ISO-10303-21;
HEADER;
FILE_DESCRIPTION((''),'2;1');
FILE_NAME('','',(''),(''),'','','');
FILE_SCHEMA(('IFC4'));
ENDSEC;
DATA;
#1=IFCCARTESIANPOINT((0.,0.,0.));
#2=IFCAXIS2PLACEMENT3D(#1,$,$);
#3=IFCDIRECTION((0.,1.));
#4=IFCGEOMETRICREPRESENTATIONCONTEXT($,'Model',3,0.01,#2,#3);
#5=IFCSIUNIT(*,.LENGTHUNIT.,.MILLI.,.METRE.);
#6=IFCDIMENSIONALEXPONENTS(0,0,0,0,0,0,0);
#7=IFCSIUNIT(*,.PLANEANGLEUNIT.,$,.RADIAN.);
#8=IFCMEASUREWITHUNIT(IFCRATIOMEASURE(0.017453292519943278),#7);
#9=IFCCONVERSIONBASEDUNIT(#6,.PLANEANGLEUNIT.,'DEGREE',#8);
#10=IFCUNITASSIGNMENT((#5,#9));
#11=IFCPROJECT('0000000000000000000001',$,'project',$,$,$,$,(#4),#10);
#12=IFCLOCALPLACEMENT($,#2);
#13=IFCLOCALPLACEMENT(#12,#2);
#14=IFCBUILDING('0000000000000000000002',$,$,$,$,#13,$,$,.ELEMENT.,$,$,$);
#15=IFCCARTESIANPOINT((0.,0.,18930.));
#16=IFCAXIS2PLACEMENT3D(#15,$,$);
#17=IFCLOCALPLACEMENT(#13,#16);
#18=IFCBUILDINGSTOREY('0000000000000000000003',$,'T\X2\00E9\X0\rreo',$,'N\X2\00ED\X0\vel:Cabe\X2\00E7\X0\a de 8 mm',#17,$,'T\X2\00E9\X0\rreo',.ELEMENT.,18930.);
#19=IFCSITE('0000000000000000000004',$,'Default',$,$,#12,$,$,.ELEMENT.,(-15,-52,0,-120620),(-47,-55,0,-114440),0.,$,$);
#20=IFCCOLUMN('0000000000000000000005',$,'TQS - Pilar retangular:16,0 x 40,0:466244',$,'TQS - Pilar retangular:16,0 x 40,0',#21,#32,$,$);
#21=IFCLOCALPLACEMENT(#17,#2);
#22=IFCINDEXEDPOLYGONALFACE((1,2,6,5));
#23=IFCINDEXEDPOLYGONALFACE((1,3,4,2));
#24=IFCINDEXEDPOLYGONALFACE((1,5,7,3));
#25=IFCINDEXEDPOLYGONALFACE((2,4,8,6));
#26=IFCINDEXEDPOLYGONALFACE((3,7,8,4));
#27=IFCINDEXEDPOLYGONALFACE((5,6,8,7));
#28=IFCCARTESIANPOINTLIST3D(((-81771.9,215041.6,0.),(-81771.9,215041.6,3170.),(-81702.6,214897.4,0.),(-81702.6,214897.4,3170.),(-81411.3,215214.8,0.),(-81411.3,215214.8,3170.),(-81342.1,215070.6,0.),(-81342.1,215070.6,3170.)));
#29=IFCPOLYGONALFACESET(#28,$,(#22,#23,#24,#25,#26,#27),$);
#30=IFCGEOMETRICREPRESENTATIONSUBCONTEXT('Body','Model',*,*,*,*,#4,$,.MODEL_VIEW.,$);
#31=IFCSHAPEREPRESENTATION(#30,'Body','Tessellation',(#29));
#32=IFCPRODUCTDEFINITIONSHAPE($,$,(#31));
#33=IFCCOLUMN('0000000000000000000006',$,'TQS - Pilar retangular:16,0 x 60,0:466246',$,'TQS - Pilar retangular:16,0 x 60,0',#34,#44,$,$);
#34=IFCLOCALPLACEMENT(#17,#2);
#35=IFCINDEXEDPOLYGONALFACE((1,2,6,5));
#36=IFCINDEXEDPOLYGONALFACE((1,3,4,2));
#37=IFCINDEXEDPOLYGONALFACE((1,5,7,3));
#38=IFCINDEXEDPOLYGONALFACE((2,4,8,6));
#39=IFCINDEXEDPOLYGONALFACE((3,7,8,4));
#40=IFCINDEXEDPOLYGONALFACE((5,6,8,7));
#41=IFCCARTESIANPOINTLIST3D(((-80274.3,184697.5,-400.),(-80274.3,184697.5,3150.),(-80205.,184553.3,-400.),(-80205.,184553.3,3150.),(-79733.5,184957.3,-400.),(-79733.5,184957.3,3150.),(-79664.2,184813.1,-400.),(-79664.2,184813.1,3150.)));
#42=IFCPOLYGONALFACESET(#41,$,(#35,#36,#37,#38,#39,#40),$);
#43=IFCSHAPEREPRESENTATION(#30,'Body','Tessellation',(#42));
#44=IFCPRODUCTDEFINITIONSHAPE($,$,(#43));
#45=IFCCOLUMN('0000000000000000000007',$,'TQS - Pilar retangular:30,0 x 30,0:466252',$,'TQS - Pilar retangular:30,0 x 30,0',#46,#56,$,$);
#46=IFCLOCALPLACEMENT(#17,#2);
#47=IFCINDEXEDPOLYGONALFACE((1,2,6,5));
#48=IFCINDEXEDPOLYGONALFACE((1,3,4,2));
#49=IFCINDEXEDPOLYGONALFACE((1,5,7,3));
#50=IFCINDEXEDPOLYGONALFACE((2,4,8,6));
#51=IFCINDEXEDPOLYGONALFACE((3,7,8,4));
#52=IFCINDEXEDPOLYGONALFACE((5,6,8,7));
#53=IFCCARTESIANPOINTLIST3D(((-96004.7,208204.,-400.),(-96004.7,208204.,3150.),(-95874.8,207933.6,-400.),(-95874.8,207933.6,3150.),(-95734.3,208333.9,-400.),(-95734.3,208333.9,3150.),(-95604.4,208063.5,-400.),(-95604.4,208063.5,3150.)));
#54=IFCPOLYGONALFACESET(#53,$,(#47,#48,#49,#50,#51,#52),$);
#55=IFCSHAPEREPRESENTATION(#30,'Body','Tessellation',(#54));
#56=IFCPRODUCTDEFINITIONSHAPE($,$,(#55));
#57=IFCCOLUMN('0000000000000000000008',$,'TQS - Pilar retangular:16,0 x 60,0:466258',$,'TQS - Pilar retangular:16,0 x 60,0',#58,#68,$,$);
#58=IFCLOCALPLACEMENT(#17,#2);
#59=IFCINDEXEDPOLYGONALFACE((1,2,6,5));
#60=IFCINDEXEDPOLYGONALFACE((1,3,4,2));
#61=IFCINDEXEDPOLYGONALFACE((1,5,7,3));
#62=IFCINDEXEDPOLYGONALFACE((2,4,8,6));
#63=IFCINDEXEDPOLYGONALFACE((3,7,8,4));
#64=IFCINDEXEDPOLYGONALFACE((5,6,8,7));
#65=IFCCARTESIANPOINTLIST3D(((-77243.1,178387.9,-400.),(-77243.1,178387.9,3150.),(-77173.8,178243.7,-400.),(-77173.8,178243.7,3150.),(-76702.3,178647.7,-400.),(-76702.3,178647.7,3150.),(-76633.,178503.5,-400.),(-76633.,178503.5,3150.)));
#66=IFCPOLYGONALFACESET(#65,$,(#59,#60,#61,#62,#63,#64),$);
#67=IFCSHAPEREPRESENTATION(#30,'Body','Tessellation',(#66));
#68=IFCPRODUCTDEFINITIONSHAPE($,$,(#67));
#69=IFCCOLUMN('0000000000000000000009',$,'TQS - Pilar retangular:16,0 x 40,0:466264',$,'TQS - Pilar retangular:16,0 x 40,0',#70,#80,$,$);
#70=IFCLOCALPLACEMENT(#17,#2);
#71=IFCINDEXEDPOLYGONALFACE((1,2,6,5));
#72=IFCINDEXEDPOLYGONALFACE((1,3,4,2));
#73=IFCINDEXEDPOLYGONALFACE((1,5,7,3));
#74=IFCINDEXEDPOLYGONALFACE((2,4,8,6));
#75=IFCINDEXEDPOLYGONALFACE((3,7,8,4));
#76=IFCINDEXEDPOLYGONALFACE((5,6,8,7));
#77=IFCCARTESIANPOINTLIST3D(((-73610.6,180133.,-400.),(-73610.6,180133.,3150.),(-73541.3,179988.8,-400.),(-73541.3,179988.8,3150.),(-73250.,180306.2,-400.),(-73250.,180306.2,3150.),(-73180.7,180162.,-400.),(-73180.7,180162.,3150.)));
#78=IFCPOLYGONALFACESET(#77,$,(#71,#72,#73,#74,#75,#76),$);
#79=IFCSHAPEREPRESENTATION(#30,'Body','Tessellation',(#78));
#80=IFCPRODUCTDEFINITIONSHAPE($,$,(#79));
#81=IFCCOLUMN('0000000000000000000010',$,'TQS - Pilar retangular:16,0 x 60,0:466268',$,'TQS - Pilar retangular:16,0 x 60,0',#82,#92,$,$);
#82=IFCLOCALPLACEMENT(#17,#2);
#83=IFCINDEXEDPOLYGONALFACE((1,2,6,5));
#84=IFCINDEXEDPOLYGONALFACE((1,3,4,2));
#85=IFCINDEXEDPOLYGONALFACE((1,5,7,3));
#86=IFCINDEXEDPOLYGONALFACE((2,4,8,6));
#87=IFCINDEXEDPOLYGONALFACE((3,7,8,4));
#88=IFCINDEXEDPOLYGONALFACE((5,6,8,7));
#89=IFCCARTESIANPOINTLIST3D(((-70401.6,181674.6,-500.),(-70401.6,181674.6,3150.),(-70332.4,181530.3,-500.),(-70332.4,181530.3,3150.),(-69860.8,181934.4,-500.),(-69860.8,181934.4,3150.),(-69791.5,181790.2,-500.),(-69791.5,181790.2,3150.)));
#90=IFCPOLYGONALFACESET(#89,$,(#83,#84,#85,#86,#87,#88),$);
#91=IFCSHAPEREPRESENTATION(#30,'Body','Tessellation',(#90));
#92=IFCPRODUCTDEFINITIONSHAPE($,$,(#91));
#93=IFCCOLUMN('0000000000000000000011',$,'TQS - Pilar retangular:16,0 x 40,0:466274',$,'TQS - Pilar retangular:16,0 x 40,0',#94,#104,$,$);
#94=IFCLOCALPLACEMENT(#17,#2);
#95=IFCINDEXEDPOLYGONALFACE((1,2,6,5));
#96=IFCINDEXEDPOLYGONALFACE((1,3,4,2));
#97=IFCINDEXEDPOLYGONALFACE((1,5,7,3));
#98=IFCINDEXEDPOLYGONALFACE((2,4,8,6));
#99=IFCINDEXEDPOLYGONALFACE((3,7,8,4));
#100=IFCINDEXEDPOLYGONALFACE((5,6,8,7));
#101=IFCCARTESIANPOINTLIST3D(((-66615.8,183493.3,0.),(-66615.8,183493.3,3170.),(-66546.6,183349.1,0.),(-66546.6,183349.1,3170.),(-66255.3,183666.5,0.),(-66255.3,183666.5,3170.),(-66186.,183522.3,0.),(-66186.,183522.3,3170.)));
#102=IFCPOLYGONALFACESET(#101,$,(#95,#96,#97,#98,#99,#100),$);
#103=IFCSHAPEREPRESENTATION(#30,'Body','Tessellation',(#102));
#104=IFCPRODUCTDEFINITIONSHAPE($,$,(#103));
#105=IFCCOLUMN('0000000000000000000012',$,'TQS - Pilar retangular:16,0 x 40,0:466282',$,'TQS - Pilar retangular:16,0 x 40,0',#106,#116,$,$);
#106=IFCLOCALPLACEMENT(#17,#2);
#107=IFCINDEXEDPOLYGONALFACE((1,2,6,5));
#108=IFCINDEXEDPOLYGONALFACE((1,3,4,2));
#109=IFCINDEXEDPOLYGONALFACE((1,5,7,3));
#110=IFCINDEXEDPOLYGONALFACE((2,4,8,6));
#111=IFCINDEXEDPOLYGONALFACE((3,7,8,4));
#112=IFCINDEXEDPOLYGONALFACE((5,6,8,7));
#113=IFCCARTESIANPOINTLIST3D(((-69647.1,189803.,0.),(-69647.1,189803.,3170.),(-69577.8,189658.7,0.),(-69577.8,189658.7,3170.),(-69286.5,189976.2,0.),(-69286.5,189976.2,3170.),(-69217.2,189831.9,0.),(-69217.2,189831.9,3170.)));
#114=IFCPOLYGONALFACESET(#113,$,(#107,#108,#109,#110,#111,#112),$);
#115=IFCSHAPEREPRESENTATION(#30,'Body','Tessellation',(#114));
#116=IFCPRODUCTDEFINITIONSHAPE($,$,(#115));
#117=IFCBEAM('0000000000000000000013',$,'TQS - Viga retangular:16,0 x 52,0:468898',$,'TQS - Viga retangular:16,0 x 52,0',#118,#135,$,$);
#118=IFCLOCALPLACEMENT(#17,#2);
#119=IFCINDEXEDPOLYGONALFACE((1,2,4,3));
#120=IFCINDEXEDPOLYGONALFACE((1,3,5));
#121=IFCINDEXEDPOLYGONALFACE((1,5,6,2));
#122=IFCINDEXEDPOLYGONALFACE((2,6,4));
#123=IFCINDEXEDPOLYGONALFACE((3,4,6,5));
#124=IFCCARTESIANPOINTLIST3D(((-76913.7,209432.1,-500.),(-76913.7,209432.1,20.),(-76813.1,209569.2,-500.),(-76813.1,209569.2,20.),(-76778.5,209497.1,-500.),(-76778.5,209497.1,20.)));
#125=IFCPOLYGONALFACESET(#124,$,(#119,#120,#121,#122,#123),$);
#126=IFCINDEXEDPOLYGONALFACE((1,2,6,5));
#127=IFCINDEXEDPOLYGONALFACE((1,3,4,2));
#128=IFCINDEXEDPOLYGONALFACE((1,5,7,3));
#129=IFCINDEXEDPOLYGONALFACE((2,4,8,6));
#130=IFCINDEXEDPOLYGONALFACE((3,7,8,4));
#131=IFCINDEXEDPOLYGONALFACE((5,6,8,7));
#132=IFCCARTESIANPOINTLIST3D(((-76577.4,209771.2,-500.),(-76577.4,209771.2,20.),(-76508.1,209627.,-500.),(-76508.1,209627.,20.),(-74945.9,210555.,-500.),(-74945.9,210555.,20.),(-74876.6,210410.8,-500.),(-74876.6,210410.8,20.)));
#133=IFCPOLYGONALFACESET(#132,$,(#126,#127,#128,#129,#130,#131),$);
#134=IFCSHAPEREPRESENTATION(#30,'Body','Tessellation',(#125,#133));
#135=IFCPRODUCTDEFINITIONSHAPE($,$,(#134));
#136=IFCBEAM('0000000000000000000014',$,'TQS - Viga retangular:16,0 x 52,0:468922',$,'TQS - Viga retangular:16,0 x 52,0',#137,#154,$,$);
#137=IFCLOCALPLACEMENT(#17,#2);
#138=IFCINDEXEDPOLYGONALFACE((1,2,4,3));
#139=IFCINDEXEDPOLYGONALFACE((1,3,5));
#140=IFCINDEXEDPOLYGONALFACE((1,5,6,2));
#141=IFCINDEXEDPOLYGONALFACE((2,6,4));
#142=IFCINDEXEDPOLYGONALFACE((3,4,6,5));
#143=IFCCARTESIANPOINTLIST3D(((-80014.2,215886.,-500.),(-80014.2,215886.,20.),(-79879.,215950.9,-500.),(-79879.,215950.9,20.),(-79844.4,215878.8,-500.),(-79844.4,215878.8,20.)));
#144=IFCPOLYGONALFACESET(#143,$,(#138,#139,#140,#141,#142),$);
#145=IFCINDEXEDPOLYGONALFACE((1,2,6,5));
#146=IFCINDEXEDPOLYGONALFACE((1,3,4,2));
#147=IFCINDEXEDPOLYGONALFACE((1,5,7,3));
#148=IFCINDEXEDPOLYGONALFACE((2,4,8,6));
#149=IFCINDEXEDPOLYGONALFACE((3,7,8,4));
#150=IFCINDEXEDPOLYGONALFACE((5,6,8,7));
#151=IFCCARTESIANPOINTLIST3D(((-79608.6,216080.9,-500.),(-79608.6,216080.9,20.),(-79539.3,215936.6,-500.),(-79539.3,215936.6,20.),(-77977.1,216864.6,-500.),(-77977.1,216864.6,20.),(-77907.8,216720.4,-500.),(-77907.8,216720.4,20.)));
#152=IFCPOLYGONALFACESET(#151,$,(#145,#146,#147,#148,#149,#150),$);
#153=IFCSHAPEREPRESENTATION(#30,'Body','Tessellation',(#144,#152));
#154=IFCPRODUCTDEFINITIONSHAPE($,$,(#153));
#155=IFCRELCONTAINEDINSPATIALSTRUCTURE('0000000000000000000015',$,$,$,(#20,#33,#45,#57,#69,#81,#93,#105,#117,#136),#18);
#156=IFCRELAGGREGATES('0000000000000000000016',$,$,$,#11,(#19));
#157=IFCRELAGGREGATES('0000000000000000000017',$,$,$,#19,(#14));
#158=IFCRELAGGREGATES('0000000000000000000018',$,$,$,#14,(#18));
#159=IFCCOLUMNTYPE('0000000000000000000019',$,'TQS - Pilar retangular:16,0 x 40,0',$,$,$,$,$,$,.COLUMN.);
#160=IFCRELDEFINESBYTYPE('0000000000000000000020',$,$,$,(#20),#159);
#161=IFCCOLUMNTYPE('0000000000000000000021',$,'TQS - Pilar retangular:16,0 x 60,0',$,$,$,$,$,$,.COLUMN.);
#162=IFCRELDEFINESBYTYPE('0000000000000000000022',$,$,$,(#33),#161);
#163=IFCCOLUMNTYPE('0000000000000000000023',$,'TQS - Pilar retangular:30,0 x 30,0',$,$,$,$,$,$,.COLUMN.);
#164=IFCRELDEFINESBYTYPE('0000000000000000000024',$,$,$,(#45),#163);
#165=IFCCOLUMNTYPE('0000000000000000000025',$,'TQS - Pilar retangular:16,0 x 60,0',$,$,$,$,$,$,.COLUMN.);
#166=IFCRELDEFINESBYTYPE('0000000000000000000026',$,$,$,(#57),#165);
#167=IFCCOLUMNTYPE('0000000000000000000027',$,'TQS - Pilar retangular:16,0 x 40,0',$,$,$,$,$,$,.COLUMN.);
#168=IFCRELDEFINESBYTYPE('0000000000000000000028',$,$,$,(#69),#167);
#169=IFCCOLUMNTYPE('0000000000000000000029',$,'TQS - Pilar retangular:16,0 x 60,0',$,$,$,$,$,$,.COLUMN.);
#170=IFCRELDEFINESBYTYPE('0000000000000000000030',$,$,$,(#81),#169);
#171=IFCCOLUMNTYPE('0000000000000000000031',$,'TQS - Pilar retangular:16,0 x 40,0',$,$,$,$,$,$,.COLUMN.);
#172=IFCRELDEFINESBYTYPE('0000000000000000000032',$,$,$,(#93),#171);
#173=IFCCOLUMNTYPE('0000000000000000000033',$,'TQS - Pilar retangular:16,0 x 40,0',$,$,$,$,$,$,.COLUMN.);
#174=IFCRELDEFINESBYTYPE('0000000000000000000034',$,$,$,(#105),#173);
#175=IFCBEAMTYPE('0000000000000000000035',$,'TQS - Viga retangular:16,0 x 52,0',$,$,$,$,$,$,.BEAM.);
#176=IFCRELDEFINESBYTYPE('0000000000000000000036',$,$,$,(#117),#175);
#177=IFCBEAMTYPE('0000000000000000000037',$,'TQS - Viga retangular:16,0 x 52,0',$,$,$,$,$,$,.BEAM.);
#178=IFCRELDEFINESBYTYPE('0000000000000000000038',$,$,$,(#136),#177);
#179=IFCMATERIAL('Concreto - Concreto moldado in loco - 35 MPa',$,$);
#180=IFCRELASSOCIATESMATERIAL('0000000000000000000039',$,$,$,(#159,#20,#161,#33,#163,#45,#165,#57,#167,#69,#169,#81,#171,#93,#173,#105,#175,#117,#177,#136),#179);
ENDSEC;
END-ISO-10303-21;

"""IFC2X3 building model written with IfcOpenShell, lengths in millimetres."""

from ifc_helpers import new_model, entity, si_unit, converted_unit, direction, frame, frame_2d, origin, origin_2d_with_axis, place, context, subcontext, project, spatial, rectangle, extrude, clip, halfspace, source, transform, mapped, material, type_object, type_shapes, element, save


model = new_model("IFC2X3")

# Units and contexts
model_context = context("Model", 3, precision=0.01, world=origin(), true_north=direction((0.0, 1.0)))
body_context = subcontext(model_context, "Body", "Model", "MODEL_VIEW")
ifc_project = project(units=[si_unit("LENGTHUNIT", "METRE", prefix="MILLI"), converted_unit("PLANEANGLEUNIT", "DEGREE", entity("IfcRatioMeasure", 0.017453292519943278), si_unit("PLANEANGLEUNIT", "RADIAN"), dimensions=[0, 0, 0, 0, 0, 0, 0])], contexts=[model_context])

# Site, building, storey
site_placement = place(None, origin())
site = spatial("IfcSite", under=ifc_project, at=site_placement, Name="Default", CompositionType="ELEMENT", RefLatitude=(-15, -52, 0, -120620), RefLongitude=(-47, -55, 0, -114440), RefElevation=0.0)
building_placement = place(site_placement, origin())
building = spatial("IfcBuilding", under=site, at=building_placement, CompositionType="ELEMENT")
storey_placement = place(building_placement, frame((0.0, 0.0, 18930.0)))
storey = spatial("IfcBuildingStorey", under=building, at=storey_placement, Name="Térreo", ObjectType="Nível:Cabeça de 8 mm", LongName="Térreo", CompositionType="ELEMENT", Elevation=18930.0)

# Columns
ifc_material = material(Name="Concreto - Concreto moldado in loco - 35 MPa")
column_type_1 = type_object("IfcColumnType", Name="TQS - Pilar retangular:16,0 x 40,0", PredefinedType="COLUMN", material=ifc_material)
shared_shape_1 = source(origin(), body_context, "Body", "SweptSolid", [
    extrude(rectangle(XDim=400.0, YDim=160.0, at=origin_2d_with_axis()), frame((-81557.0, 215056.1, 18930.0), z_axis=(0.0, 0.0, 1.0), x_axis=(-0.90138, -0.43303, 0.0)), (0.0, 0.0, 1.0), 3170.0),
])
type_shapes(column_type_1, [shared_shape_1])
column_1_placement = place(storey_placement, frame((0.0, 0.0, -18930.0)))
element("IfcColumn", 1, at=column_1_placement, inside=storey, type_object=column_type_1, material=ifc_material, Name="TQS - Pilar retangular:16,0 x 40,0:466244", ObjectType="TQS - Pilar retangular:16,0 x 40,0", context=body_context, shape_type="MappedRepresentation", body=[
    mapped(shared_shape_1, transform((0.0, 0.0, 0.0), scale=1.0)),
])
column_type_2 = type_object("IfcColumnType", Name="TQS - Pilar retangular:16,0 x 60,0", PredefinedType="COLUMN", material=ifc_material)
shared_shape_2 = source(origin(), body_context, "Body", "SweptSolid", [
    extrude(rectangle(XDim=600.0, YDim=160.0, at=origin_2d_with_axis()), frame((-79969.3, 184755.3, 18530.0), z_axis=(0.0, 0.0, 1.0), x_axis=(-0.90138, -0.43303, 0.0)), (0.0, 0.0, 1.0), 3550.0),
])
type_shapes(column_type_2, [shared_shape_2])
column_2_placement = place(storey_placement, frame((0.0, 0.0, -18930.0)))
element("IfcColumn", 2, at=column_2_placement, inside=storey, type_object=column_type_2, material=ifc_material, Name="TQS - Pilar retangular:16,0 x 60,0:466246", ObjectType="TQS - Pilar retangular:16,0 x 60,0", context=body_context, shape_type="MappedRepresentation", body=[
    mapped(shared_shape_2, transform((0.0, 0.0, 0.0), scale=1.0)),
])
column_type_3 = type_object("IfcColumnType", Name="TQS - Pilar retangular:30,0 x 30,0", PredefinedType="COLUMN", material=ifc_material)
shared_shape_3 = source(origin(), body_context, "Body", "SweptSolid", [
    extrude(rectangle(XDim=300.0, YDim=300.0, at=origin_2d_with_axis()), frame((-95804.5, 208133.8, 18530.0), z_axis=(0.0, 0.0, 1.0), x_axis=(-0.90138, -0.43303, 0.0)), (0.0, 0.0, 1.0), 3550.0),
])
type_shapes(column_type_3, [shared_shape_3])
column_3_placement = place(storey_placement, frame((0.0, 0.0, -18930.0)))
element("IfcColumn", 3, at=column_3_placement, inside=storey, type_object=column_type_3, material=ifc_material, Name="TQS - Pilar retangular:30,0 x 30,0:466252", ObjectType="TQS - Pilar retangular:30,0 x 30,0", context=body_context, shape_type="MappedRepresentation", body=[
    mapped(shared_shape_3, transform((0.0, 0.0, 0.0), scale=1.0)),
])
column_type_4 = type_object("IfcColumnType", Name="TQS - Pilar retangular:16,0 x 60,0", PredefinedType="COLUMN", material=ifc_material)
shared_shape_4 = source(origin(), body_context, "Body", "SweptSolid", [
    extrude(rectangle(XDim=600.0, YDim=160.0, at=origin_2d_with_axis()), frame((-76938.1, 178445.7, 18530.0), z_axis=(0.0, 0.0, 1.0), x_axis=(-0.90138, -0.43303, 0.0)), (0.0, 0.0, 1.0), 3550.0),
])
type_shapes(column_type_4, [shared_shape_4])
column_4_placement = place(storey_placement, frame((0.0, 0.0, -18930.0)))
element("IfcColumn", 4, at=column_4_placement, inside=storey, type_object=column_type_4, material=ifc_material, Name="TQS - Pilar retangular:16,0 x 60,0:466258", ObjectType="TQS - Pilar retangular:16,0 x 60,0", context=body_context, shape_type="MappedRepresentation", body=[
    mapped(shared_shape_4, transform((0.0, 0.0, 0.0), scale=1.0)),
])
column_type_5 = type_object("IfcColumnType", Name="TQS - Pilar retangular:16,0 x 40,0", PredefinedType="COLUMN", material=ifc_material)
shared_shape_5 = source(origin(), body_context, "Body", "SweptSolid", [
    extrude(rectangle(XDim=400.0, YDim=160.0, at=origin_2d_with_axis()), frame((-73395.6, 180147.5, 18530.0), z_axis=(0.0, 0.0, 1.0), x_axis=(-0.90138, -0.43303, 0.0)), (0.0, 0.0, 1.0), 3550.0),
])
type_shapes(column_type_5, [shared_shape_5])
column_5_placement = place(storey_placement, frame((0.0, 0.0, -18930.0)))
element("IfcColumn", 5, at=column_5_placement, inside=storey, type_object=column_type_5, material=ifc_material, Name="TQS - Pilar retangular:16,0 x 40,0:466264", ObjectType="TQS - Pilar retangular:16,0 x 40,0", context=body_context, shape_type="MappedRepresentation", body=[
    mapped(shared_shape_5, transform((0.0, 0.0, 0.0), scale=1.0)),
])
column_type_6 = type_object("IfcColumnType", Name="TQS - Pilar retangular:16,0 x 60,0", PredefinedType="COLUMN", material=ifc_material)
shared_shape_6 = source(origin(), body_context, "Body", "SweptSolid", [
    extrude(rectangle(XDim=600.0, YDim=160.0, at=origin_2d_with_axis()), frame((-70096.6, 181732.4, 18430.0), z_axis=(0.0, 0.0, 1.0), x_axis=(-0.90138, -0.43303, 0.0)), (0.0, 0.0, 1.0), 3650.0),
])
type_shapes(column_type_6, [shared_shape_6])
column_6_placement = place(storey_placement, frame((0.0, 0.0, -18930.0)))
element("IfcColumn", 6, at=column_6_placement, inside=storey, type_object=column_type_6, material=ifc_material, Name="TQS - Pilar retangular:16,0 x 60,0:466268", ObjectType="TQS - Pilar retangular:16,0 x 60,0", context=body_context, shape_type="MappedRepresentation", body=[
    mapped(shared_shape_6, transform((0.0, 0.0, 0.0), scale=1.0)),
])
column_type_7 = type_object("IfcColumnType", Name="TQS - Pilar retangular:16,0 x 40,0", PredefinedType="COLUMN", material=ifc_material)
shared_shape_7 = source(origin(), body_context, "Body", "SweptSolid", [
    extrude(rectangle(XDim=400.0, YDim=160.0, at=origin_2d_with_axis()), frame((-66400.9, 183507.8, 18930.0), z_axis=(0.0, 0.0, 1.0), x_axis=(-0.90138, -0.43303, 0.0)), (0.0, 0.0, 1.0), 3170.0),
])
type_shapes(column_type_7, [shared_shape_7])
column_7_placement = place(storey_placement, frame((0.0, 0.0, -18930.0)))
element("IfcColumn", 7, at=column_7_placement, inside=storey, type_object=column_type_7, material=ifc_material, Name="TQS - Pilar retangular:16,0 x 40,0:466274", ObjectType="TQS - Pilar retangular:16,0 x 40,0", context=body_context, shape_type="MappedRepresentation", body=[
    mapped(shared_shape_7, transform((0.0, 0.0, 0.0), scale=1.0)),
])
column_type_8 = type_object("IfcColumnType", Name="TQS - Pilar retangular:16,0 x 40,0", PredefinedType="COLUMN", material=ifc_material)
shared_shape_8 = source(origin(), body_context, "Body", "SweptSolid", [
    extrude(rectangle(XDim=400.0, YDim=160.0, at=origin_2d_with_axis()), frame((-69432.1, 189817.4, 18930.0), z_axis=(0.0, 0.0, 1.0), x_axis=(-0.90138, -0.43303, 0.0)), (0.0, 0.0, 1.0), 3170.0),
])
type_shapes(column_type_8, [shared_shape_8])
column_8_placement = place(storey_placement, frame((0.0, 0.0, -18930.0)))
element("IfcColumn", 8, at=column_8_placement, inside=storey, type_object=column_type_8, material=ifc_material, Name="TQS - Pilar retangular:16,0 x 40,0:466282", ObjectType="TQS - Pilar retangular:16,0 x 40,0", context=body_context, shape_type="MappedRepresentation", body=[
    mapped(shared_shape_8, transform((0.0, 0.0, 0.0), scale=1.0)),
])

# Beams
beam_type_1 = type_object("IfcBeamType", Name="TQS - Viga retangular:16,0 x 52,0", PredefinedType="BEAM", material=ifc_material)
shared_shape_9 = source(origin(), body_context, "Body", "SweptSolid", [
    clip(extrude(rectangle(XDim=520.0, YDim=80.0, at=frame_2d((0.0, 0.0), x_axis=(0.0, 1.0))), frame((-76795.8, 209533.1, 18690.0), z_axis=(-0.90138, -0.43303, 0.0), x_axis=(0.43303, -0.90138, 0.0)), (0.0, 0.0, 1.0), 150.0), halfspace(frame((-76712.6, 209706.2, 18950.0), z_axis=(-0.806264, 0.591556, 0.0), x_axis=(0.591556, 0.806264, 0.0)), False)),
    extrude(rectangle(XDim=520.0, YDim=160.0, at=frame_2d((0.0, 0.0), x_axis=(1.0, 0.0))), frame((-74911.2, 210482.9, 18690.0), z_axis=(-0.90138, -0.43303, 0.0), x_axis=(0.0, 0.0, -1.0)), (0.0, 0.0, 1.0), 1810.0),
])
type_shapes(beam_type_1, [shared_shape_9])
beam_1_placement = place(storey_placement, frame((0.0, 0.0, -18930.0)))
element("IfcBeam", 9, at=beam_1_placement, inside=storey, type_object=beam_type_1, material=ifc_material, Name="TQS - Viga retangular:16,0 x 52,0:468898", ObjectType="TQS - Viga retangular:16,0 x 52,0", context=body_context, shape_type="MappedRepresentation", body=[
    mapped(shared_shape_9, transform((0.0, 0.0, 0.0), scale=1.0)),
])
beam_type_2 = type_object("IfcBeamType", Name="TQS - Viga retangular:16,0 x 52,0", PredefinedType="BEAM", material=ifc_material)
shared_shape_10 = source(origin(), body_context, "Body", "SweptSolid", [
    clip(extrude(rectangle(XDim=520.0, YDim=80.0, at=frame_2d((0.0, 0.0), x_axis=(1.0, 0.0))), frame((-79861.7, 215914.9, 18690.0), z_axis=(-0.90138, -0.43303, 0.0), x_axis=(0.0, 0.0, -1.0)), (0.0, 0.0, 1.0), 150.0), halfspace(frame((-79674.5, 215871.7, 18950.0), z_axis=(-0.042093, -0.999114, 0.0), x_axis=(0.999114, -0.042093, 0.0)), False)),
    extrude(rectangle(XDim=520.0, YDim=160.0, at=frame_2d((0.0, 0.0), x_axis=(1.0, 0.0))), frame((-77942.4, 216792.5, 18690.0), z_axis=(-0.90138, -0.43303, 0.0), x_axis=(0.0, 0.0, -1.0)), (0.0, 0.0, 1.0), 1810.0),
])
type_shapes(beam_type_2, [shared_shape_10])
beam_2_placement = place(storey_placement, frame((0.0, 0.0, -18930.0)))
element("IfcBeam", 10, at=beam_2_placement, inside=storey, type_object=beam_type_2, material=ifc_material, Name="TQS - Viga retangular:16,0 x 52,0:468922", ObjectType="TQS - Viga retangular:16,0 x 52,0", context=body_context, shape_type="MappedRepresentation", body=[
    mapped(shared_shape_10, transform((0.0, 0.0, 0.0), scale=1.0)),
])

save(model, "model.ifc")
